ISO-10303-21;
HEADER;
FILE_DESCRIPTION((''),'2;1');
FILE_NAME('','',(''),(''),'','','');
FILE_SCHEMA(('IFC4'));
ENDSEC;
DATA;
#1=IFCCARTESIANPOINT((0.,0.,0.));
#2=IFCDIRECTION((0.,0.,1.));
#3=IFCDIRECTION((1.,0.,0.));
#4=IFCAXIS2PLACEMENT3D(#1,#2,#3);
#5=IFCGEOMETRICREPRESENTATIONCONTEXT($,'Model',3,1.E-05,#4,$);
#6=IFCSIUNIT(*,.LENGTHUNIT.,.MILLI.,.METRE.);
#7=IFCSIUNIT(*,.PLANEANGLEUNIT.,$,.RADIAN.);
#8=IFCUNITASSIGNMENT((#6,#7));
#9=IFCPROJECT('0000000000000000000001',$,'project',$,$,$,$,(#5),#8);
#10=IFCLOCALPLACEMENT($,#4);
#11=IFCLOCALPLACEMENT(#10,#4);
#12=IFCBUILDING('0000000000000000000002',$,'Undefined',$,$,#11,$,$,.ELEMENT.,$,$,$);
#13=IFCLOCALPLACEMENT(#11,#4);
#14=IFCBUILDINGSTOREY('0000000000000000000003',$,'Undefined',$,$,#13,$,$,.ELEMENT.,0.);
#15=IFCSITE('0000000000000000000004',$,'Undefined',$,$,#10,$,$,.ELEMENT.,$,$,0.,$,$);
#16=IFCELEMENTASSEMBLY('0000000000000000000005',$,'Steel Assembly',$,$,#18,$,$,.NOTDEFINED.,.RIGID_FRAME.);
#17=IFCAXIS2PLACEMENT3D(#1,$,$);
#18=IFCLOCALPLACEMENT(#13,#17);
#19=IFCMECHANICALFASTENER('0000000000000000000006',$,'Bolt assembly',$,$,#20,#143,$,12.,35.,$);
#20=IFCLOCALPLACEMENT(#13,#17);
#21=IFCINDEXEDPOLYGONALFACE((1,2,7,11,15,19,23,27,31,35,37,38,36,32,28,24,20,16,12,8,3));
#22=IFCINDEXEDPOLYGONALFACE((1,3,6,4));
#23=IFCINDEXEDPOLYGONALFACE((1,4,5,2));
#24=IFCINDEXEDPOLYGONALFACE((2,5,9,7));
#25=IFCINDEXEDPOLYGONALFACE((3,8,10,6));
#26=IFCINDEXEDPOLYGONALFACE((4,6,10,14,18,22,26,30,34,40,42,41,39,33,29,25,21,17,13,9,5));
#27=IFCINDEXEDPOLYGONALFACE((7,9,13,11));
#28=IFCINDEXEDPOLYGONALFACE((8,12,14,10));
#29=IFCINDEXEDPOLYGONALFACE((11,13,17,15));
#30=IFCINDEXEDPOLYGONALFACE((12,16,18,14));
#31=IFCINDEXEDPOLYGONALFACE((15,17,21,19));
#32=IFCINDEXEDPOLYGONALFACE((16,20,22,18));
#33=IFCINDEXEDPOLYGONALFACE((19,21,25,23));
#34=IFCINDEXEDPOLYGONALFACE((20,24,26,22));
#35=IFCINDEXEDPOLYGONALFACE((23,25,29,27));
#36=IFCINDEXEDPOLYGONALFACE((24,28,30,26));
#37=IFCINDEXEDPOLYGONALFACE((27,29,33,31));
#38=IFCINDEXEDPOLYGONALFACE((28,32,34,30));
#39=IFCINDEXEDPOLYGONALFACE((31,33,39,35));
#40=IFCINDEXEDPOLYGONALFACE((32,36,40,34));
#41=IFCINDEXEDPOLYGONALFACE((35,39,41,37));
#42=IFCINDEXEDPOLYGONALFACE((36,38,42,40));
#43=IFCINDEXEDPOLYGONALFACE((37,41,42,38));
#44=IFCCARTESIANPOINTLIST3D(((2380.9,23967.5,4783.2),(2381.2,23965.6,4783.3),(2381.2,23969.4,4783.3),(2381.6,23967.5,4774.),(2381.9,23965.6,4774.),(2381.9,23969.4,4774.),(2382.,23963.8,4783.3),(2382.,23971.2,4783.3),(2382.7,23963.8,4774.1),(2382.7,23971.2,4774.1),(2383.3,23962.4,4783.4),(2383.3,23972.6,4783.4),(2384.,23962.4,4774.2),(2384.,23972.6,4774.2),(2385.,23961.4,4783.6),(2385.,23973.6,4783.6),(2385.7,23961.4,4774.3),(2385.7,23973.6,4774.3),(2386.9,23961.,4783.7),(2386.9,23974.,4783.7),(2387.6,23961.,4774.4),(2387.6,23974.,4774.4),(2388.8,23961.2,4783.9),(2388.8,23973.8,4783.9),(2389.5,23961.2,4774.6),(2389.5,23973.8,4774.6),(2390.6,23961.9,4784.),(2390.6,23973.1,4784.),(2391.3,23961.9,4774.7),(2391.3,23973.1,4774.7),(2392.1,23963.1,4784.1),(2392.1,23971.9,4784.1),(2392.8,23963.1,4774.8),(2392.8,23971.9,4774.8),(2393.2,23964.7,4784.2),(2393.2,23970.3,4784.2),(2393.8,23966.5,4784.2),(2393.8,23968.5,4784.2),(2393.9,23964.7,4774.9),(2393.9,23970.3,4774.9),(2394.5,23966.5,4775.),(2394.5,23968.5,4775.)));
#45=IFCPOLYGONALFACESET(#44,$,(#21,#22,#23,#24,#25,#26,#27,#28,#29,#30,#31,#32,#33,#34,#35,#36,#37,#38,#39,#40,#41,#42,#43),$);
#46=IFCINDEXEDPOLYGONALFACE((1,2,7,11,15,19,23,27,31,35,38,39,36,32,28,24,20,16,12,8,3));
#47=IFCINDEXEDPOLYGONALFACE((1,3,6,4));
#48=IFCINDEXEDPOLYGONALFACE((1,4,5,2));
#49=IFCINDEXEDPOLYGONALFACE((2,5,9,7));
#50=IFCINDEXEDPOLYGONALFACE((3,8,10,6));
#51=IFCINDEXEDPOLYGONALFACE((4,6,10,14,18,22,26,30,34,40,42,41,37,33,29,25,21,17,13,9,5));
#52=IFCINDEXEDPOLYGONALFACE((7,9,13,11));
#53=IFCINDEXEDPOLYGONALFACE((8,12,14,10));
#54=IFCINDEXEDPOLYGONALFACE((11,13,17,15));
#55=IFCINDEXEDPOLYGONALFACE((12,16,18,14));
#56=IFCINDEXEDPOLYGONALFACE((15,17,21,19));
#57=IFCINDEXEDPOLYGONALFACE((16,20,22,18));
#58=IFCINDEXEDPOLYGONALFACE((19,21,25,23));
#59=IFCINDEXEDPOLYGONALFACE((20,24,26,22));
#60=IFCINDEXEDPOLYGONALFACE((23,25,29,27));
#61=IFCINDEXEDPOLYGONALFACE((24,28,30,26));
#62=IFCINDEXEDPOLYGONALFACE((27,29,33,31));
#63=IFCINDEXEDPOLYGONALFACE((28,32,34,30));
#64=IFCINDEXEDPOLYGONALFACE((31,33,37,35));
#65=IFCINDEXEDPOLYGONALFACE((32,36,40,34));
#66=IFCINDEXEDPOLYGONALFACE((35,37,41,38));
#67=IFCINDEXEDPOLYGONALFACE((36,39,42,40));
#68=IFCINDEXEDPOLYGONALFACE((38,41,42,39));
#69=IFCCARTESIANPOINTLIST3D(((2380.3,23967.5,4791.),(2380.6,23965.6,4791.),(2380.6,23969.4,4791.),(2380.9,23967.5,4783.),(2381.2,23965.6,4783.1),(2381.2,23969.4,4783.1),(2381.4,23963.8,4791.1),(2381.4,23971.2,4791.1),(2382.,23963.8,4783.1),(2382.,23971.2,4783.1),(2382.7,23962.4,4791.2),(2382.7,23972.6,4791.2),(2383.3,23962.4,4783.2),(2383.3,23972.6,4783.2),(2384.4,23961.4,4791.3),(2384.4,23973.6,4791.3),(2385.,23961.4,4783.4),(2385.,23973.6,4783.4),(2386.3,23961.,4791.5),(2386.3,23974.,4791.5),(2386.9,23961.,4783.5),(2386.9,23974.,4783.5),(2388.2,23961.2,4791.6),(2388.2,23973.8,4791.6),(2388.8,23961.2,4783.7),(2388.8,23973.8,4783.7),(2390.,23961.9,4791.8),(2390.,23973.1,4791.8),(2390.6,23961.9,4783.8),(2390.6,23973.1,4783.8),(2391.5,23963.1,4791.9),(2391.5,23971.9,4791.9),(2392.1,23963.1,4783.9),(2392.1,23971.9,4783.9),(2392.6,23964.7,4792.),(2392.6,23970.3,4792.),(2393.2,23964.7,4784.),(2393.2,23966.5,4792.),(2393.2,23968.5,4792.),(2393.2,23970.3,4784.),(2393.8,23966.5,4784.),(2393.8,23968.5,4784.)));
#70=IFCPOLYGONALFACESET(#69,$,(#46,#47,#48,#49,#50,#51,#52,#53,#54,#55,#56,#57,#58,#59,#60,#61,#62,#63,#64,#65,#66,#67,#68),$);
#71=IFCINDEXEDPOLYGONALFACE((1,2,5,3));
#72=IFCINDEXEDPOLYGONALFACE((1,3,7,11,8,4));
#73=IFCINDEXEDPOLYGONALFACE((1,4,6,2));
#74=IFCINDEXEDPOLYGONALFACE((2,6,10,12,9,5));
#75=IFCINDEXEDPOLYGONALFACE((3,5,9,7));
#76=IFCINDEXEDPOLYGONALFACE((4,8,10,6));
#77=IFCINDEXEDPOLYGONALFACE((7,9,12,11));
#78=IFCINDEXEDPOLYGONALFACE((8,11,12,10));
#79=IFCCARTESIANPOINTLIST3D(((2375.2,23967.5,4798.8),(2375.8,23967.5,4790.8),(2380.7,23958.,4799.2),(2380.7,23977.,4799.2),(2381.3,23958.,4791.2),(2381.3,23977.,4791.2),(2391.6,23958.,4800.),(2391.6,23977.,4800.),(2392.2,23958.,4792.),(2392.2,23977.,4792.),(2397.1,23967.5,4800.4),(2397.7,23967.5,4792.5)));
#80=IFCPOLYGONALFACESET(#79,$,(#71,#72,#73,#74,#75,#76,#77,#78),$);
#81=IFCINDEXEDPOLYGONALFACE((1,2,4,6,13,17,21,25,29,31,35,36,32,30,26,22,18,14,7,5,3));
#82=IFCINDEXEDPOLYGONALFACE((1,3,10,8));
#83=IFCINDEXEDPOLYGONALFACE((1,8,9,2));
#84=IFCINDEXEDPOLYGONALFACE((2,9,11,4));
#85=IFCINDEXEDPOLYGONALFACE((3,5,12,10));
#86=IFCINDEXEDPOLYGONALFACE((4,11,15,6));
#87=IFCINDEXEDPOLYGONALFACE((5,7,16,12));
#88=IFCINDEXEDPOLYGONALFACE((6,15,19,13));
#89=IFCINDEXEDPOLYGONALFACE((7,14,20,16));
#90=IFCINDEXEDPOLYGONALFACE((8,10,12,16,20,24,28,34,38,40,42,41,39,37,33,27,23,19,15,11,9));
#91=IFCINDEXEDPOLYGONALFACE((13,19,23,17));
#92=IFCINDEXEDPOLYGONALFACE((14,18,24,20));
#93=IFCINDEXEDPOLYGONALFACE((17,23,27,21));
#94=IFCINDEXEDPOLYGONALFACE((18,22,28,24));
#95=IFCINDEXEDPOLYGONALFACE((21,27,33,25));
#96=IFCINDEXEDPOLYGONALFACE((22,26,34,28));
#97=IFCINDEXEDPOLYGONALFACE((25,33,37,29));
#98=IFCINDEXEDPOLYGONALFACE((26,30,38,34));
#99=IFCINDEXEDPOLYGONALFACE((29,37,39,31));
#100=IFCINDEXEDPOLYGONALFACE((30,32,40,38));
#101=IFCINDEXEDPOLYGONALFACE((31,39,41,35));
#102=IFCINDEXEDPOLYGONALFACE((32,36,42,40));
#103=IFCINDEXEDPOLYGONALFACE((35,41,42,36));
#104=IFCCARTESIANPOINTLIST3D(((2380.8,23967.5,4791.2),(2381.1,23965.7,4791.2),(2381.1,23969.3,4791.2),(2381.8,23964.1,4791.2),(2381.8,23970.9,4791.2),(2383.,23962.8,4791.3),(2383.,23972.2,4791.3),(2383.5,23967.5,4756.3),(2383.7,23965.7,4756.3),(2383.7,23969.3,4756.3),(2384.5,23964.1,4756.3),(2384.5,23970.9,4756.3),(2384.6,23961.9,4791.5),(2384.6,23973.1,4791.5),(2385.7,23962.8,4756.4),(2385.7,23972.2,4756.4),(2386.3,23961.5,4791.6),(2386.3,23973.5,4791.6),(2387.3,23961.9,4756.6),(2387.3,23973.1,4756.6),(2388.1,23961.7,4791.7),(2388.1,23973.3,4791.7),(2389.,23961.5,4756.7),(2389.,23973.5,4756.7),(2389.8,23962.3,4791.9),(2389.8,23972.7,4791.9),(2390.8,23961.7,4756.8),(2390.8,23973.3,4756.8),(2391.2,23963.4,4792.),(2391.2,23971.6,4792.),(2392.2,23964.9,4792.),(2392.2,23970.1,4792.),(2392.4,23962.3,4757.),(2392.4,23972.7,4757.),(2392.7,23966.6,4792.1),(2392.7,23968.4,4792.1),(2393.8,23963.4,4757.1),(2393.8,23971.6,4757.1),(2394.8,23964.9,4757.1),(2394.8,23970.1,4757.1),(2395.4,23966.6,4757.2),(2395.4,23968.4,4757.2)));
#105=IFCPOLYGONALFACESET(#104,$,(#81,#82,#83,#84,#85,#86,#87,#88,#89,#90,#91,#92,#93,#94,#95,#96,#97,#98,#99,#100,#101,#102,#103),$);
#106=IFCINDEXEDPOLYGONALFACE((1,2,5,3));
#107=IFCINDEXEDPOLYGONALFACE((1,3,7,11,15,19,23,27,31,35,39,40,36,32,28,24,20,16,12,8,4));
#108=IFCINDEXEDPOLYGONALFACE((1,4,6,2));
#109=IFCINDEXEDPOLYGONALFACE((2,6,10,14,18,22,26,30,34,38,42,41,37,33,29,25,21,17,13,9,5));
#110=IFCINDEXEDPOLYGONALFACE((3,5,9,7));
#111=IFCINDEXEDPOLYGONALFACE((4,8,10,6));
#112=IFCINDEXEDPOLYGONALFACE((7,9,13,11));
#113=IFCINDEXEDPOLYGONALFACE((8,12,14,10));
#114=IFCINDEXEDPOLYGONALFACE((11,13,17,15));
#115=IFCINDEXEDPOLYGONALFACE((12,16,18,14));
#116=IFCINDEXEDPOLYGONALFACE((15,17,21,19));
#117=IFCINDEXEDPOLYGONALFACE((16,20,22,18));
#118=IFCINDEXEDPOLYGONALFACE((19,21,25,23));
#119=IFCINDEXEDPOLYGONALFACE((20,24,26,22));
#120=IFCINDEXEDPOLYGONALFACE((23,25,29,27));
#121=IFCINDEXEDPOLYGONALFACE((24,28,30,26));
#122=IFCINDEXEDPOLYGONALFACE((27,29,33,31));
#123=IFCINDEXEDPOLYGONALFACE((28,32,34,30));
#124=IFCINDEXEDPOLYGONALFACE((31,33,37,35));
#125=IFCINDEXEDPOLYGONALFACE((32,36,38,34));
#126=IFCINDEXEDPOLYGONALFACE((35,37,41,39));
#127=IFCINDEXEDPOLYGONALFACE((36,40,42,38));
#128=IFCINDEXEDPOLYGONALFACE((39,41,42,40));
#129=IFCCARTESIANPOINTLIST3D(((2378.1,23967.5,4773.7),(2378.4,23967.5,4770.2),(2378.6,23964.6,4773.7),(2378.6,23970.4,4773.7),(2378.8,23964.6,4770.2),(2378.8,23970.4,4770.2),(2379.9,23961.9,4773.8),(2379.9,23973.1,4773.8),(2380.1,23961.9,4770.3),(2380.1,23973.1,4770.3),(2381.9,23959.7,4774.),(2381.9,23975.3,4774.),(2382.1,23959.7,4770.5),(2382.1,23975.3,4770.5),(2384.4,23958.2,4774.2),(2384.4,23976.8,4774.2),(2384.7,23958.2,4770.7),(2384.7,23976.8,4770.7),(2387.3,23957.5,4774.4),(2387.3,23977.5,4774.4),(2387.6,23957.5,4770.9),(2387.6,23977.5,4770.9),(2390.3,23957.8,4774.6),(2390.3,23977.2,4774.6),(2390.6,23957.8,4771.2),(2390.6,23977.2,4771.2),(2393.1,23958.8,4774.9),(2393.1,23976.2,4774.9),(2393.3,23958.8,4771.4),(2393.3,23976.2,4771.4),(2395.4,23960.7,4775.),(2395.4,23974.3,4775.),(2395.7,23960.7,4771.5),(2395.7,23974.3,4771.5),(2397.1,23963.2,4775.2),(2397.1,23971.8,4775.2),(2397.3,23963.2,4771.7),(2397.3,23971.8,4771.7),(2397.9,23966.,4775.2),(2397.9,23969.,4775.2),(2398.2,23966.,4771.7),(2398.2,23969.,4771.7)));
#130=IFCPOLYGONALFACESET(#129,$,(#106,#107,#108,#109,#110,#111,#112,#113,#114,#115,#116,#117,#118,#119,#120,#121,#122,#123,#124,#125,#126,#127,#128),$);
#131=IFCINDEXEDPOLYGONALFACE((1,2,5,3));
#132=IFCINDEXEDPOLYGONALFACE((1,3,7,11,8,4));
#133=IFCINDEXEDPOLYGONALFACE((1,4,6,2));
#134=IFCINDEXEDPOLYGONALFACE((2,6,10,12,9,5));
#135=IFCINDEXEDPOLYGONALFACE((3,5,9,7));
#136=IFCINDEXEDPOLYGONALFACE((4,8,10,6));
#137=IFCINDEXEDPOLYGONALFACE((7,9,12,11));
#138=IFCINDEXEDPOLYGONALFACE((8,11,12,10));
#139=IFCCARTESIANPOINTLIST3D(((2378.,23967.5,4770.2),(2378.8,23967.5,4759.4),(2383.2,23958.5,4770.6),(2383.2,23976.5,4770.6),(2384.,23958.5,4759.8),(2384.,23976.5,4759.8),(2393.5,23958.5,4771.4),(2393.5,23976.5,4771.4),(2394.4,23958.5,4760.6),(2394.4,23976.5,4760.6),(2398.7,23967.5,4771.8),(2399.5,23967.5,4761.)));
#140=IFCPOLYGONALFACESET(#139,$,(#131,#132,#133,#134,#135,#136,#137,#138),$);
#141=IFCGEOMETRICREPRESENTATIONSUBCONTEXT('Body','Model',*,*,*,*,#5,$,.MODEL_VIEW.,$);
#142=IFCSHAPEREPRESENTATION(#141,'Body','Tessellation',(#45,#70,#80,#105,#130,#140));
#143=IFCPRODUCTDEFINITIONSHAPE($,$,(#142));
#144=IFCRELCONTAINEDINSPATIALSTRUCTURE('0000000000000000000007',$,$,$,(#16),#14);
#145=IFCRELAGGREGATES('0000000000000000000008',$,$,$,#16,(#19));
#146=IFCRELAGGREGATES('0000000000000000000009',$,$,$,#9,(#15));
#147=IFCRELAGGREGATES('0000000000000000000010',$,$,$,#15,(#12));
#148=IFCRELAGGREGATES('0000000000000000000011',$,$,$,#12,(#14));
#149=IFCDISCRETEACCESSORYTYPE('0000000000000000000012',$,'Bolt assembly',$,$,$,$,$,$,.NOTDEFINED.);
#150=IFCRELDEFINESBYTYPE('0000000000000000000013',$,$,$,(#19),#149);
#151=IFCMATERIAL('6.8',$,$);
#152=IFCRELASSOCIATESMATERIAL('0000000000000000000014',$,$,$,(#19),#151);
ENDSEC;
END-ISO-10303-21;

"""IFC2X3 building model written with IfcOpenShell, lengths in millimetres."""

from ifc_helpers import new_model, si_unit, frame, origin_with_axes, origin_2d_with_axis, place, context, subcontext, project, spatial, polyline, circle, outline, extrude, source, transform, mapped, material, type_object, element, aggregate, save


model = new_model("IFC2X3")

# Units and contexts
model_context = context("Model", 3, precision=1e-05, world=origin_with_axes())
body_context = subcontext(model_context, "Body", "Model", "MODEL_VIEW")
ifc_project = project(units=[si_unit("LENGTHUNIT", "METRE", prefix="MILLI"), si_unit("PLANEANGLEUNIT", "RADIAN")], contexts=[model_context])

# Site, building, storey
site_placement = place(None, origin_with_axes())
site = spatial("IfcSite", under=ifc_project, at=site_placement, Name="Undefined", CompositionType="ELEMENT", RefElevation=0.0)
building_placement = place(site_placement, origin_with_axes())
building = spatial("IfcBuilding", under=site, at=building_placement, Name="Undefined", CompositionType="ELEMENT")
storey_placement = place(building_placement, origin_with_axes())
storey = spatial("IfcBuildingStorey", under=building, at=storey_placement, Name="Undefined", CompositionType="ELEMENT", Elevation=0.0)

# Element assembly, mechanical fastener
ifc_material_1 = material(Name="6.8")
discrete_accessory_type_1 = type_object("IfcDiscreteAccessoryType", Name="Bolt assembly")
shared_shape_1 = source(origin_with_axes(), body_context, "Body", "SweptSolid", [
    extrude(circle(Radius=6.5, at=origin_2d_with_axis()), frame((0.0, -0.1, 0.0), z_axis=(0.0, 1.0, 0.0), x_axis=(1.0, 0.0, 0.0)), (0.0, 0.0, 1.0), 9.3),
    extrude(circle(Radius=6.5, at=origin_2d_with_axis()), frame((0.0, -7.9, 0.0), z_axis=(0.0, 1.0, 0.0), x_axis=(1.0, 0.0, 0.0)), (0.0, 0.0, 1.0), 8.0),
    extrude(outline(polyline([(11.0, 0.0), (5.5, 9.5), (-5.5, 9.5), (-11.0, 0.0), (-5.5, -9.5), (5.5, -9.5), (11.0, 0.0)])), frame((0.0, -16.0, 0.0), z_axis=(0.0, 1.0, 0.0), x_axis=(1.0, 0.0, 0.0)), (0.0, 0.0, 1.0), 8.0),
    extrude(circle(Radius=6.0, at=origin_2d_with_axis()), frame((0.0, -8.0, 0.0), z_axis=(0.0, 1.0, 0.0), x_axis=(1.0, 0.0, 0.0)), (0.0, 0.0, 1.0), 35.0),
    extrude(circle(Radius=10.0, at=origin_2d_with_axis()), frame((0.0, 9.2, 0.0), z_axis=(0.0, 1.0, 0.0), x_axis=(1.0, 0.0, 0.0)), (0.0, 0.0, 1.0), 3.5),
    extrude(outline(polyline([(10.4, 0.0), (5.2, 9.0), (-5.2, 9.0), (-10.4, 0.0), (-5.2, -9.0), (5.2, -9.0), (10.4, 0.0)])), frame((0.0, 12.7, 0.0), z_axis=(0.0, 1.0, 0.0), x_axis=(1.0, 0.0, 0.0)), (0.0, 0.0, 1.0), 10.8),
])
assembly_1_placement = place(storey_placement, origin_with_axes())
assembly_1 = element("IfcElementAssembly", 1, at=assembly_1_placement, inside=storey, Name="Steel Assembly", AssemblyPlace="NOTDEFINED", PredefinedType="RIGID_FRAME")
mechanical_fastener_1_placement = place(assembly_1_placement, frame((2387.4, 23967.5, 4783.6), z_axis=(0.0, -1.0, 0.0), x_axis=(-0.997054, 0.0, -0.076696)))
mechanical_fastener_1 = element("IfcMechanicalFastener", 2, at=mechanical_fastener_1_placement, type_object=discrete_accessory_type_1, material=ifc_material_1, Name="Bolt assembly", NominalDiameter=12.0, NominalLength=35.0, context=body_context, shape_type="MappedRepresentation", body=[
    mapped(shared_shape_1, transform((0.0, 0.0, 0.0))),
])
aggregate(assembly_1, [mechanical_fastener_1])

save(model, "model.ifc")
